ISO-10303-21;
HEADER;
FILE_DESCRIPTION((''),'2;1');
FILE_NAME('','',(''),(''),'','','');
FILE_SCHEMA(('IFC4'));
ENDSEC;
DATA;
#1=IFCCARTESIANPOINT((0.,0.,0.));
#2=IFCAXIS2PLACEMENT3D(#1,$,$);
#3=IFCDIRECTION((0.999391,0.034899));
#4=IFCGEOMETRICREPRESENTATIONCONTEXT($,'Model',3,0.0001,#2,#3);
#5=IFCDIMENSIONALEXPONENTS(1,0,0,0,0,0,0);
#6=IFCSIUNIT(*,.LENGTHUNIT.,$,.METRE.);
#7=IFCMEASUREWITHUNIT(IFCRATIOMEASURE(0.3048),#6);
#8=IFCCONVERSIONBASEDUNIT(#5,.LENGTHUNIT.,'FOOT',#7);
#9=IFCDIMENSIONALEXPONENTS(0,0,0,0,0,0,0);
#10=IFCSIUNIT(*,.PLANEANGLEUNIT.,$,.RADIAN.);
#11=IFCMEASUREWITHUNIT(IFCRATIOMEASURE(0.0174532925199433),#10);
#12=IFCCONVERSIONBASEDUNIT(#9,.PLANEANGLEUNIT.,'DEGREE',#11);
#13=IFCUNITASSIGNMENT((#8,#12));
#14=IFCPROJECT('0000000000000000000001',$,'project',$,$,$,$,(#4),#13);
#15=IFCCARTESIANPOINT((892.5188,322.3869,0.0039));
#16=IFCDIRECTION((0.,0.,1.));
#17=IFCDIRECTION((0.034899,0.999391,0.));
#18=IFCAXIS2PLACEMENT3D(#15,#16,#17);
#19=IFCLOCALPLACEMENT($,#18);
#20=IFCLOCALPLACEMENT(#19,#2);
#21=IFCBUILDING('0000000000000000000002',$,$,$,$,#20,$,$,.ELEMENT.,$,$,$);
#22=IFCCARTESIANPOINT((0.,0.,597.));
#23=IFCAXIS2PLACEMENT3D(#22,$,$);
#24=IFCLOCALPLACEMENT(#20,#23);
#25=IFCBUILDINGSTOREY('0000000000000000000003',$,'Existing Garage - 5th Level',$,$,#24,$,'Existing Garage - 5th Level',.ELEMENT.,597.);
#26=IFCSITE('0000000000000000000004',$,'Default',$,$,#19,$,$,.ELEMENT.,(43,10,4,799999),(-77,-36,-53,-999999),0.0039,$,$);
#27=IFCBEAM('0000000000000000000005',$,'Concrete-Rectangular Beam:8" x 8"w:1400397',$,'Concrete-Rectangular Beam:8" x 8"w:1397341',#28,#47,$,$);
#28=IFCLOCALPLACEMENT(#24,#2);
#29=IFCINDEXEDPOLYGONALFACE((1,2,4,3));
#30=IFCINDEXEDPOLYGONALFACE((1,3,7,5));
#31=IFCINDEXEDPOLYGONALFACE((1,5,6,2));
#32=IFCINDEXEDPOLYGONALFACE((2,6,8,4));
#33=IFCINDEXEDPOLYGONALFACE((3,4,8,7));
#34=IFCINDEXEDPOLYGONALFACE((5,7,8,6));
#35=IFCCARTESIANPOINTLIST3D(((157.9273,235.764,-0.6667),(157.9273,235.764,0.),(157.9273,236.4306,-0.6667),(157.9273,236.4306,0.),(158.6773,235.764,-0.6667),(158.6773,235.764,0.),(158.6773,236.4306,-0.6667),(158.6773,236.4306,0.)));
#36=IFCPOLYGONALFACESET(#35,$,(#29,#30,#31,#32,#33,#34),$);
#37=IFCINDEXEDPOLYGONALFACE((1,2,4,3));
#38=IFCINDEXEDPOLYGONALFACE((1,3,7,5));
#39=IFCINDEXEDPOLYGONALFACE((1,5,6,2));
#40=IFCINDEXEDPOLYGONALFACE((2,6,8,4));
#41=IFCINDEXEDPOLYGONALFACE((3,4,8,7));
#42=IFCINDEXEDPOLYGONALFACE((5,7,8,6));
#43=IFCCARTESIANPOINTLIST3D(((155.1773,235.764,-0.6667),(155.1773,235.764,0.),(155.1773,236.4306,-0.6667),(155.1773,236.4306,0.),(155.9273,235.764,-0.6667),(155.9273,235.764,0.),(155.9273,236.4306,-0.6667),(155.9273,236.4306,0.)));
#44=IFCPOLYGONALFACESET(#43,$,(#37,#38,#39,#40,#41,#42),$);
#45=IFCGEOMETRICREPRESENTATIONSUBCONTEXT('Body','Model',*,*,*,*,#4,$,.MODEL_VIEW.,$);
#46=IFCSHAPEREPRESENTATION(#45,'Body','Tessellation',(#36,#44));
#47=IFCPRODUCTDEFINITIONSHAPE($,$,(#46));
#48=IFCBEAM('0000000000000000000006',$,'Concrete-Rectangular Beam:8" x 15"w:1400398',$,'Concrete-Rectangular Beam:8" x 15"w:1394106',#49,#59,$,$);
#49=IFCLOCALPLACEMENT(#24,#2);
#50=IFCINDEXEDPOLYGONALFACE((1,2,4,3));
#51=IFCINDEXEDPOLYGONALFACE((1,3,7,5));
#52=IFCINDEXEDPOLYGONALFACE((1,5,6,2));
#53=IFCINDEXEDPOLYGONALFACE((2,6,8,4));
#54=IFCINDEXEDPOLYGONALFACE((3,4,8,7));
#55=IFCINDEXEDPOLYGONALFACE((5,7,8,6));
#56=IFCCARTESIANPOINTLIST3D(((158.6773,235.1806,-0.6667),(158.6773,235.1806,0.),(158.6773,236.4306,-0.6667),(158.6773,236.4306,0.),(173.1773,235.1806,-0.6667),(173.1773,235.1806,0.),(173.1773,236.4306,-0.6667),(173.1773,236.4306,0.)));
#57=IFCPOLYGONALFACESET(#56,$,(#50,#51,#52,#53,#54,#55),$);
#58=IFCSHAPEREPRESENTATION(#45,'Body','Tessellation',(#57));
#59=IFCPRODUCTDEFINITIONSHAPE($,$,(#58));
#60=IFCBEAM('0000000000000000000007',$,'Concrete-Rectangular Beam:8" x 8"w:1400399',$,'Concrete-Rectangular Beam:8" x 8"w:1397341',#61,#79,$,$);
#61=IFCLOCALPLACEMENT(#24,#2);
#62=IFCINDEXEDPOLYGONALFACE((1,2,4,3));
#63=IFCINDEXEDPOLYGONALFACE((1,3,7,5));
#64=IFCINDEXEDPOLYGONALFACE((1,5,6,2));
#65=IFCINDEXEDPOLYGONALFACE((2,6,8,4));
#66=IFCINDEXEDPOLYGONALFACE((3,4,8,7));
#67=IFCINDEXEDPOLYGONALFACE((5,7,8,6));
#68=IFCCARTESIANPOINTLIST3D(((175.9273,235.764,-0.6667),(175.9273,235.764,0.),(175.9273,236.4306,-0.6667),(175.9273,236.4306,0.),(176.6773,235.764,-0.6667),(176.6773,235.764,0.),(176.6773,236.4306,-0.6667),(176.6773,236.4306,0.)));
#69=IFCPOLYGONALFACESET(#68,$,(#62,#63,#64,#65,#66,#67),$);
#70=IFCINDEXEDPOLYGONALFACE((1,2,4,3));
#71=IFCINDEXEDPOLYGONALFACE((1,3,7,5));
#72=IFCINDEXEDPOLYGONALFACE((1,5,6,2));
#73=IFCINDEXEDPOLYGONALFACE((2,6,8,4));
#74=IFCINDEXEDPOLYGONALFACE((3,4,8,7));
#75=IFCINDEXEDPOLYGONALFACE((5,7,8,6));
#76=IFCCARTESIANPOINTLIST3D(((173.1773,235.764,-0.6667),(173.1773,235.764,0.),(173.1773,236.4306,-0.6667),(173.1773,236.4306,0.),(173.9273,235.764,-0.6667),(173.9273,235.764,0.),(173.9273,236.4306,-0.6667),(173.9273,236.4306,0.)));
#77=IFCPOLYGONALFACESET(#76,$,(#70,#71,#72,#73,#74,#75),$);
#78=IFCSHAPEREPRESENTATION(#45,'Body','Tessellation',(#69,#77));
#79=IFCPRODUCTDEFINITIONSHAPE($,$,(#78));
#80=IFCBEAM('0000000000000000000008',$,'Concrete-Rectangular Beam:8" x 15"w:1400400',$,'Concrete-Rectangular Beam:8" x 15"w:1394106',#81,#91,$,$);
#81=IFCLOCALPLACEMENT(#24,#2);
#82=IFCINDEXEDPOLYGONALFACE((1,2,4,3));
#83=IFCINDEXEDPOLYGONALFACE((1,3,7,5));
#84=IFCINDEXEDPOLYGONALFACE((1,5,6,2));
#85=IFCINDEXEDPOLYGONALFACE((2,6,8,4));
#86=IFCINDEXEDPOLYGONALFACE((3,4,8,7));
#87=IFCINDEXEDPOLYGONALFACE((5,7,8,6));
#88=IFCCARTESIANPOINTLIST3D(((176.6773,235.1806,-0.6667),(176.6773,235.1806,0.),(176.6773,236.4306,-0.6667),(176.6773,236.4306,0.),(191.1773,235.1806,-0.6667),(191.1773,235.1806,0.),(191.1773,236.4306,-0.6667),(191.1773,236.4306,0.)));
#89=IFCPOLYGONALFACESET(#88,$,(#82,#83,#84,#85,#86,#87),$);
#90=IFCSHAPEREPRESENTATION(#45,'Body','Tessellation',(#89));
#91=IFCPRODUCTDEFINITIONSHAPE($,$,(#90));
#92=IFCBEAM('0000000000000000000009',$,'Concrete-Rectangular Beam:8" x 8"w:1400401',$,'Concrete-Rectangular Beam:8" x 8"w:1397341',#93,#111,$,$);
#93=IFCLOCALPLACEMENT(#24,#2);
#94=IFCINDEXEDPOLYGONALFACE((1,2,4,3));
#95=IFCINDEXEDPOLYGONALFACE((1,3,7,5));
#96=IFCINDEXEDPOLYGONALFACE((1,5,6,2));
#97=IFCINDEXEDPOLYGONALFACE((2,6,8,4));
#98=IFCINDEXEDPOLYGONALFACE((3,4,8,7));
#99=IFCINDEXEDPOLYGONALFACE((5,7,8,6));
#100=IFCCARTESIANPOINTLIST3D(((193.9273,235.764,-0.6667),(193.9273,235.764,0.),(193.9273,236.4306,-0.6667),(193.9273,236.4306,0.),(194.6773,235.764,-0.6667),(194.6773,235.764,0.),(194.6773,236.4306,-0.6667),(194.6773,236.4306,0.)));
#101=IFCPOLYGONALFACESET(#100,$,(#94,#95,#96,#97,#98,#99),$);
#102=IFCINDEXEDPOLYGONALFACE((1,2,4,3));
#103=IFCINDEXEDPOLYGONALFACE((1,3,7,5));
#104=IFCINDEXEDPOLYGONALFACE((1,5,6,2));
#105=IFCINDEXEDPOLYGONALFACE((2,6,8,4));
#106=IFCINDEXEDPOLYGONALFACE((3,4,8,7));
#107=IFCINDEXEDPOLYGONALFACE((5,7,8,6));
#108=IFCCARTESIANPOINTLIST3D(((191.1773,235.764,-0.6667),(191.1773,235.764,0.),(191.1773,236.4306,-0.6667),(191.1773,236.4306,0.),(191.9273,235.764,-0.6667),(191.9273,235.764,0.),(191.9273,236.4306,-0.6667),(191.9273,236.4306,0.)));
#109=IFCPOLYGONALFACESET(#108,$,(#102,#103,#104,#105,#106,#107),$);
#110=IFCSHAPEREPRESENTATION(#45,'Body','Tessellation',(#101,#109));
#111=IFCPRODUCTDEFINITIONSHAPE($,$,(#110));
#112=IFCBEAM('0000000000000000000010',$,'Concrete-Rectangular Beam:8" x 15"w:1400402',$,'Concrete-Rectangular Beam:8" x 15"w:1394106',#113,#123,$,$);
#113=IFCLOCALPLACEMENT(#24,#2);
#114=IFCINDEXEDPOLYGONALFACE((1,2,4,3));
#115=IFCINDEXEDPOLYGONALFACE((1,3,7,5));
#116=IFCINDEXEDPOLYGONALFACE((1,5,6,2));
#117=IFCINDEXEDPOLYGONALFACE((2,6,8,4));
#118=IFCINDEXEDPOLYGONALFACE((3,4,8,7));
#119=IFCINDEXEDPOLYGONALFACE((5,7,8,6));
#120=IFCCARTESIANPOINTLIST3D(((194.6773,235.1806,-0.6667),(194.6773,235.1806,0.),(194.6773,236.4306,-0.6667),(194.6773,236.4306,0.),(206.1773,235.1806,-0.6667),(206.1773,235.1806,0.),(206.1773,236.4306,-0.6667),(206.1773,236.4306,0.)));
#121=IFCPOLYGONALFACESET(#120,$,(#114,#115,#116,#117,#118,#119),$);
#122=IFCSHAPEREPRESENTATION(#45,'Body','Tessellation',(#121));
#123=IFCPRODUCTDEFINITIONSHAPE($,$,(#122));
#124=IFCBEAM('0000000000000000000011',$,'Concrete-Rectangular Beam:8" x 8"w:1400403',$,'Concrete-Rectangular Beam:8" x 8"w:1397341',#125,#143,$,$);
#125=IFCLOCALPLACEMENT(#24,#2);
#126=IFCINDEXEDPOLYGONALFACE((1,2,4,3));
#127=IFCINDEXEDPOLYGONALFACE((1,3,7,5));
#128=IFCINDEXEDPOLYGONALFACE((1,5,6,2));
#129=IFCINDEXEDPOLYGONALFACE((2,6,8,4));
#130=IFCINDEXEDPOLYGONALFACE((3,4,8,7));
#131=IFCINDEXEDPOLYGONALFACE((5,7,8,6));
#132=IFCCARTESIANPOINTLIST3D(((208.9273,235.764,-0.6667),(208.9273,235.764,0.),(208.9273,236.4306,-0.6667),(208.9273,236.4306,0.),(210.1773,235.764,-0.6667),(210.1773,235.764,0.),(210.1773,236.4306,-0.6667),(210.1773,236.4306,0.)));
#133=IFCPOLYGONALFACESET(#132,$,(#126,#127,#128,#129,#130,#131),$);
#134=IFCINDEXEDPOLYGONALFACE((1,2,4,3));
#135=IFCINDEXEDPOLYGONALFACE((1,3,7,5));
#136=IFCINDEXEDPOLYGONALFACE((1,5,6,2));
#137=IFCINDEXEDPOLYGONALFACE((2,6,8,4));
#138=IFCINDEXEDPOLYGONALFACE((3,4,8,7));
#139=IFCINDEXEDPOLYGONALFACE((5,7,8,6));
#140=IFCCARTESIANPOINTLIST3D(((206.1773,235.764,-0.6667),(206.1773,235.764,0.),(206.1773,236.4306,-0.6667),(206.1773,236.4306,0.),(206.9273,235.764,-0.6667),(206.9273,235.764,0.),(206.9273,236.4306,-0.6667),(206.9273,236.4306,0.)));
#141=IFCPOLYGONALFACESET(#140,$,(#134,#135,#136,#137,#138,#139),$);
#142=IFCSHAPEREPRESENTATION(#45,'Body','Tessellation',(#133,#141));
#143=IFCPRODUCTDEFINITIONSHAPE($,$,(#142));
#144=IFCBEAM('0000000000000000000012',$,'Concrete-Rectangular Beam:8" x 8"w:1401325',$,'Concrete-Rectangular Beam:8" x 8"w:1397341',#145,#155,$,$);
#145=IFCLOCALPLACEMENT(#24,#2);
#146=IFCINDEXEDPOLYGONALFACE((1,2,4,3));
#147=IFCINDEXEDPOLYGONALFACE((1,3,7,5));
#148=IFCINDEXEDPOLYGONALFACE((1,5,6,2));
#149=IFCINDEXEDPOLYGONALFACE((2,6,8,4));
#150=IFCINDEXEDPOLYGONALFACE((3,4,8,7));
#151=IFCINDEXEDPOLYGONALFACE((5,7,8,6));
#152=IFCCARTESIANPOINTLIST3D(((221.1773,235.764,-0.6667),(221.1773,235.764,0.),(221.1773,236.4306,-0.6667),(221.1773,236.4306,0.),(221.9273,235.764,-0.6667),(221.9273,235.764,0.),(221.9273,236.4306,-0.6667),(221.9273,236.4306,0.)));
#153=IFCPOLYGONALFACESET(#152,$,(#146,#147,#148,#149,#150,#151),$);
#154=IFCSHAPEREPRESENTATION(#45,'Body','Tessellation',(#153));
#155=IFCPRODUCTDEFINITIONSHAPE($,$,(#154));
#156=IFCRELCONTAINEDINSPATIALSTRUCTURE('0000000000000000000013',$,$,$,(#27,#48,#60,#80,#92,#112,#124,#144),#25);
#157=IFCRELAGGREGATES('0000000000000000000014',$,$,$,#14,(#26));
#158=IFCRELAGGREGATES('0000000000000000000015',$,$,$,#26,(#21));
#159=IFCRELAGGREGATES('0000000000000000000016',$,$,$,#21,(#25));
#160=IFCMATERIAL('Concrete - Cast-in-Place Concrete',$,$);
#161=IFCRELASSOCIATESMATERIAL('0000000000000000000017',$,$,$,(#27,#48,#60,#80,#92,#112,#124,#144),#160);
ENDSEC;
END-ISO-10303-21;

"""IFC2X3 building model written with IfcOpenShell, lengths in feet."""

from ifc_helpers import new_model, entity, si_unit, converted_unit, direction, frame, frame_2d, origin, origin_2d_with_axis, place, context, subcontext, project, spatial, rectangle, extrude, material, element, save


model = new_model("IFC2X3")

# Units and contexts
model_context = context("Model", 3, precision=0.0001, world=origin(), true_north=direction((0.999391, 0.034899)))
body_context = subcontext(model_context, "Body", "Model", "MODEL_VIEW")
ifc_project = project(units=[converted_unit("LENGTHUNIT", "FOOT", entity("IfcRatioMeasure", 0.3048), si_unit("LENGTHUNIT", "METRE"), dimensions=[1, 0, 0, 0, 0, 0, 0]), converted_unit("PLANEANGLEUNIT", "DEGREE", entity("IfcRatioMeasure", 0.0174532925199433), si_unit("PLANEANGLEUNIT", "RADIAN"), dimensions=[0, 0, 0, 0, 0, 0, 0])], contexts=[model_context])

# Site, building, storey
site_placement = place(None, frame((892.5188, 322.3869, 0.0039), z_axis=(0.0, 0.0, 1.0), x_axis=(0.034899, 0.999391, 0.0)))
site = spatial("IfcSite", under=ifc_project, at=site_placement, Name="Default", CompositionType="ELEMENT", RefLatitude=(43, 10, 4, 799999), RefLongitude=(-77, -36, -53, -999999), RefElevation=0.0039)
building_placement = place(site_placement, origin())
building = spatial("IfcBuilding", under=site, at=building_placement, CompositionType="ELEMENT")
storey_placement = place(building_placement, frame((0.0, 0.0, 597.0)))
storey = spatial("IfcBuildingStorey", under=building, at=storey_placement, Name="Existing Garage - 5th Level", LongName="Existing Garage - 5th Level", CompositionType="ELEMENT", Elevation=597.0)

# Beams
ifc_material_1 = material(Name="Concrete - Cast-in-Place Concrete")
beam_1_placement = place(storey_placement, frame((154.5106, 236.0973, 0.0)))
element("IfcBeam", 1, at=beam_1_placement, inside=storey, material=ifc_material_1, Name="Concrete-Rectangular Beam:8\" x 8\"w:1400397", ObjectType="Concrete-Rectangular Beam:8\" x 8\"w:1397341", context=body_context, shape_type="SweptSolid", body=[
    extrude(rectangle(XDim=0.6667, YDim=0.6667, at=frame_2d((0.0, 0.0), x_axis=(1.0, 0.0))), frame((3.4167, 0.0, -0.3333), z_axis=(1.0, 0.0, 0.0), x_axis=(0.0, 0.0, -1.0)), (0.0, 0.0, 1.0), 0.75),
    extrude(rectangle(XDim=0.6667, YDim=0.6667, at=frame_2d((0.0, 0.0), x_axis=(1.0, 0.0))), frame((0.6667, 0.0, -0.3333), z_axis=(1.0, 0.0, 0.0), x_axis=(0.0, 0.0, -1.0)), (0.0, 0.0, 1.0), 0.75),
])
beam_2_placement = place(storey_placement, frame((158.6773, 235.8056, 0.0)))
element("IfcBeam", 2, at=beam_2_placement, inside=storey, material=ifc_material_1, Name="Concrete-Rectangular Beam:8\" x 15\"w:1400398", ObjectType="Concrete-Rectangular Beam:8\" x 15\"w:1394106", context=body_context, shape_type="SweptSolid", body=[
    extrude(rectangle(XDim=0.6667, YDim=1.25, at=frame_2d((0.0, 0.0), x_axis=(1.0, 0.0))), frame((0.0, 0.0, -0.3333), z_axis=(1.0, 0.0, 0.0), x_axis=(0.0, 0.0, -1.0)), (0.0, 0.0, 1.0), 14.5),
])
beam_3_placement = place(storey_placement, frame((173.1773, 236.0973, 0.0)))
element("IfcBeam", 3, at=beam_3_placement, inside=storey, material=ifc_material_1, Name="Concrete-Rectangular Beam:8\" x 8\"w:1400399", ObjectType="Concrete-Rectangular Beam:8\" x 8\"w:1397341", context=body_context, shape_type="SweptSolid", body=[
    extrude(rectangle(XDim=0.6667, YDim=0.6667, at=origin_2d_with_axis()), frame((2.75, 0.0, -0.3333), z_axis=(1.0, 0.0, 0.0), x_axis=(0.0, 0.0, -1.0)), (0.0, 0.0, 1.0), 0.75),
    extrude(rectangle(XDim=0.6667, YDim=0.6667, at=frame_2d((0.0, 0.0), x_axis=(0.0, 1.0))), frame((0.0, 0.0, -0.3333), z_axis=(1.0, 0.0, 0.0), x_axis=(0.0, -1.0, 0.0)), (0.0, 0.0, 1.0), 0.75),
])
beam_4_placement = place(storey_placement, frame((176.6773, 235.8056, 0.0)))
element("IfcBeam", 4, at=beam_4_placement, inside=storey, material=ifc_material_1, Name="Concrete-Rectangular Beam:8\" x 15\"w:1400400", ObjectType="Concrete-Rectangular Beam:8\" x 15\"w:1394106", context=body_context, shape_type="SweptSolid", body=[
    extrude(rectangle(XDim=0.6667, YDim=1.25, at=frame_2d((0.0, 0.0), x_axis=(1.0, 0.0))), frame((0.0, 0.0, -0.3333), z_axis=(1.0, 0.0, 0.0), x_axis=(0.0, 0.0, -1.0)), (0.0, 0.0, 1.0), 14.5),
])
beam_5_placement = place(storey_placement, frame((191.1773, 236.0973, 0.0)))
element("IfcBeam", 5, at=beam_5_placement, inside=storey, material=ifc_material_1, Name="Concrete-Rectangular Beam:8\" x 8\"w:1400401", ObjectType="Concrete-Rectangular Beam:8\" x 8\"w:1397341", context=body_context, shape_type="SweptSolid", body=[
    extrude(rectangle(XDim=0.6667, YDim=0.6667, at=origin_2d_with_axis()), frame((2.75, 0.0, -0.3333), z_axis=(1.0, 0.0, 0.0), x_axis=(0.0, 0.0, -1.0)), (0.0, 0.0, 1.0), 0.75),
    extrude(rectangle(XDim=0.6667, YDim=0.6667, at=frame_2d((0.0, 0.0), x_axis=(0.0, 1.0))), frame((0.0, 0.0, -0.3333), z_axis=(1.0, 0.0, 0.0), x_axis=(0.0, -1.0, 0.0)), (0.0, 0.0, 1.0), 0.75),
])
beam_6_placement = place(storey_placement, frame((194.6773, 235.8056, 0.0)))
element("IfcBeam", 6, at=beam_6_placement, inside=storey, material=ifc_material_1, Name="Concrete-Rectangular Beam:8\" x 15\"w:1400402", ObjectType="Concrete-Rectangular Beam:8\" x 15\"w:1394106", context=body_context, shape_type="SweptSolid", body=[
    extrude(rectangle(XDim=0.6667, YDim=1.25, at=frame_2d((0.0, 0.0), x_axis=(1.0, 0.0))), frame((0.0, 0.0, -0.3333), z_axis=(1.0, 0.0, 0.0), x_axis=(0.0, 0.0, -1.0)), (0.0, 0.0, 1.0), 11.5),
])
beam_7_placement = place(storey_placement, frame((206.1773, 236.0973, 0.0)))
element("IfcBeam", 7, at=beam_7_placement, inside=storey, material=ifc_material_1, Name="Concrete-Rectangular Beam:8\" x 8\"w:1400403", ObjectType="Concrete-Rectangular Beam:8\" x 8\"w:1397341", context=body_context, shape_type="SweptSolid", body=[
    extrude(rectangle(XDim=0.6667, YDim=0.6667, at=frame_2d((0.0, 0.0), x_axis=(1.0, 0.0))), frame((2.75, 0.0, -0.3333), z_axis=(1.0, 0.0, 0.0), x_axis=(0.0, 0.0, -1.0)), (0.0, 0.0, 1.0), 1.25),
    extrude(rectangle(XDim=0.6667, YDim=0.6667, at=frame_2d((0.0, 0.0), x_axis=(0.0, 1.0))), frame((0.0, 0.0, -0.3333), z_axis=(1.0, 0.0, 0.0), x_axis=(0.0, -1.0, 0.0)), (0.0, 0.0, 1.0), 0.75),
])
beam_8_placement = place(storey_placement, frame((221.1773, 236.0973, 0.0)))
element("IfcBeam", 8, at=beam_8_placement, inside=storey, material=ifc_material_1, Name="Concrete-Rectangular Beam:8\" x 8\"w:1401325", ObjectType="Concrete-Rectangular Beam:8\" x 8\"w:1397341", context=body_context, shape_type="SweptSolid", body=[
    extrude(rectangle(XDim=0.6667, YDim=0.6667, at=origin_2d_with_axis()), frame((0.0, 0.0, -0.3333), z_axis=(1.0, 0.0, 0.0), x_axis=(0.0, 0.0, -1.0)), (0.0, 0.0, 1.0), 0.75),
])

save(model, "model.ifc")
